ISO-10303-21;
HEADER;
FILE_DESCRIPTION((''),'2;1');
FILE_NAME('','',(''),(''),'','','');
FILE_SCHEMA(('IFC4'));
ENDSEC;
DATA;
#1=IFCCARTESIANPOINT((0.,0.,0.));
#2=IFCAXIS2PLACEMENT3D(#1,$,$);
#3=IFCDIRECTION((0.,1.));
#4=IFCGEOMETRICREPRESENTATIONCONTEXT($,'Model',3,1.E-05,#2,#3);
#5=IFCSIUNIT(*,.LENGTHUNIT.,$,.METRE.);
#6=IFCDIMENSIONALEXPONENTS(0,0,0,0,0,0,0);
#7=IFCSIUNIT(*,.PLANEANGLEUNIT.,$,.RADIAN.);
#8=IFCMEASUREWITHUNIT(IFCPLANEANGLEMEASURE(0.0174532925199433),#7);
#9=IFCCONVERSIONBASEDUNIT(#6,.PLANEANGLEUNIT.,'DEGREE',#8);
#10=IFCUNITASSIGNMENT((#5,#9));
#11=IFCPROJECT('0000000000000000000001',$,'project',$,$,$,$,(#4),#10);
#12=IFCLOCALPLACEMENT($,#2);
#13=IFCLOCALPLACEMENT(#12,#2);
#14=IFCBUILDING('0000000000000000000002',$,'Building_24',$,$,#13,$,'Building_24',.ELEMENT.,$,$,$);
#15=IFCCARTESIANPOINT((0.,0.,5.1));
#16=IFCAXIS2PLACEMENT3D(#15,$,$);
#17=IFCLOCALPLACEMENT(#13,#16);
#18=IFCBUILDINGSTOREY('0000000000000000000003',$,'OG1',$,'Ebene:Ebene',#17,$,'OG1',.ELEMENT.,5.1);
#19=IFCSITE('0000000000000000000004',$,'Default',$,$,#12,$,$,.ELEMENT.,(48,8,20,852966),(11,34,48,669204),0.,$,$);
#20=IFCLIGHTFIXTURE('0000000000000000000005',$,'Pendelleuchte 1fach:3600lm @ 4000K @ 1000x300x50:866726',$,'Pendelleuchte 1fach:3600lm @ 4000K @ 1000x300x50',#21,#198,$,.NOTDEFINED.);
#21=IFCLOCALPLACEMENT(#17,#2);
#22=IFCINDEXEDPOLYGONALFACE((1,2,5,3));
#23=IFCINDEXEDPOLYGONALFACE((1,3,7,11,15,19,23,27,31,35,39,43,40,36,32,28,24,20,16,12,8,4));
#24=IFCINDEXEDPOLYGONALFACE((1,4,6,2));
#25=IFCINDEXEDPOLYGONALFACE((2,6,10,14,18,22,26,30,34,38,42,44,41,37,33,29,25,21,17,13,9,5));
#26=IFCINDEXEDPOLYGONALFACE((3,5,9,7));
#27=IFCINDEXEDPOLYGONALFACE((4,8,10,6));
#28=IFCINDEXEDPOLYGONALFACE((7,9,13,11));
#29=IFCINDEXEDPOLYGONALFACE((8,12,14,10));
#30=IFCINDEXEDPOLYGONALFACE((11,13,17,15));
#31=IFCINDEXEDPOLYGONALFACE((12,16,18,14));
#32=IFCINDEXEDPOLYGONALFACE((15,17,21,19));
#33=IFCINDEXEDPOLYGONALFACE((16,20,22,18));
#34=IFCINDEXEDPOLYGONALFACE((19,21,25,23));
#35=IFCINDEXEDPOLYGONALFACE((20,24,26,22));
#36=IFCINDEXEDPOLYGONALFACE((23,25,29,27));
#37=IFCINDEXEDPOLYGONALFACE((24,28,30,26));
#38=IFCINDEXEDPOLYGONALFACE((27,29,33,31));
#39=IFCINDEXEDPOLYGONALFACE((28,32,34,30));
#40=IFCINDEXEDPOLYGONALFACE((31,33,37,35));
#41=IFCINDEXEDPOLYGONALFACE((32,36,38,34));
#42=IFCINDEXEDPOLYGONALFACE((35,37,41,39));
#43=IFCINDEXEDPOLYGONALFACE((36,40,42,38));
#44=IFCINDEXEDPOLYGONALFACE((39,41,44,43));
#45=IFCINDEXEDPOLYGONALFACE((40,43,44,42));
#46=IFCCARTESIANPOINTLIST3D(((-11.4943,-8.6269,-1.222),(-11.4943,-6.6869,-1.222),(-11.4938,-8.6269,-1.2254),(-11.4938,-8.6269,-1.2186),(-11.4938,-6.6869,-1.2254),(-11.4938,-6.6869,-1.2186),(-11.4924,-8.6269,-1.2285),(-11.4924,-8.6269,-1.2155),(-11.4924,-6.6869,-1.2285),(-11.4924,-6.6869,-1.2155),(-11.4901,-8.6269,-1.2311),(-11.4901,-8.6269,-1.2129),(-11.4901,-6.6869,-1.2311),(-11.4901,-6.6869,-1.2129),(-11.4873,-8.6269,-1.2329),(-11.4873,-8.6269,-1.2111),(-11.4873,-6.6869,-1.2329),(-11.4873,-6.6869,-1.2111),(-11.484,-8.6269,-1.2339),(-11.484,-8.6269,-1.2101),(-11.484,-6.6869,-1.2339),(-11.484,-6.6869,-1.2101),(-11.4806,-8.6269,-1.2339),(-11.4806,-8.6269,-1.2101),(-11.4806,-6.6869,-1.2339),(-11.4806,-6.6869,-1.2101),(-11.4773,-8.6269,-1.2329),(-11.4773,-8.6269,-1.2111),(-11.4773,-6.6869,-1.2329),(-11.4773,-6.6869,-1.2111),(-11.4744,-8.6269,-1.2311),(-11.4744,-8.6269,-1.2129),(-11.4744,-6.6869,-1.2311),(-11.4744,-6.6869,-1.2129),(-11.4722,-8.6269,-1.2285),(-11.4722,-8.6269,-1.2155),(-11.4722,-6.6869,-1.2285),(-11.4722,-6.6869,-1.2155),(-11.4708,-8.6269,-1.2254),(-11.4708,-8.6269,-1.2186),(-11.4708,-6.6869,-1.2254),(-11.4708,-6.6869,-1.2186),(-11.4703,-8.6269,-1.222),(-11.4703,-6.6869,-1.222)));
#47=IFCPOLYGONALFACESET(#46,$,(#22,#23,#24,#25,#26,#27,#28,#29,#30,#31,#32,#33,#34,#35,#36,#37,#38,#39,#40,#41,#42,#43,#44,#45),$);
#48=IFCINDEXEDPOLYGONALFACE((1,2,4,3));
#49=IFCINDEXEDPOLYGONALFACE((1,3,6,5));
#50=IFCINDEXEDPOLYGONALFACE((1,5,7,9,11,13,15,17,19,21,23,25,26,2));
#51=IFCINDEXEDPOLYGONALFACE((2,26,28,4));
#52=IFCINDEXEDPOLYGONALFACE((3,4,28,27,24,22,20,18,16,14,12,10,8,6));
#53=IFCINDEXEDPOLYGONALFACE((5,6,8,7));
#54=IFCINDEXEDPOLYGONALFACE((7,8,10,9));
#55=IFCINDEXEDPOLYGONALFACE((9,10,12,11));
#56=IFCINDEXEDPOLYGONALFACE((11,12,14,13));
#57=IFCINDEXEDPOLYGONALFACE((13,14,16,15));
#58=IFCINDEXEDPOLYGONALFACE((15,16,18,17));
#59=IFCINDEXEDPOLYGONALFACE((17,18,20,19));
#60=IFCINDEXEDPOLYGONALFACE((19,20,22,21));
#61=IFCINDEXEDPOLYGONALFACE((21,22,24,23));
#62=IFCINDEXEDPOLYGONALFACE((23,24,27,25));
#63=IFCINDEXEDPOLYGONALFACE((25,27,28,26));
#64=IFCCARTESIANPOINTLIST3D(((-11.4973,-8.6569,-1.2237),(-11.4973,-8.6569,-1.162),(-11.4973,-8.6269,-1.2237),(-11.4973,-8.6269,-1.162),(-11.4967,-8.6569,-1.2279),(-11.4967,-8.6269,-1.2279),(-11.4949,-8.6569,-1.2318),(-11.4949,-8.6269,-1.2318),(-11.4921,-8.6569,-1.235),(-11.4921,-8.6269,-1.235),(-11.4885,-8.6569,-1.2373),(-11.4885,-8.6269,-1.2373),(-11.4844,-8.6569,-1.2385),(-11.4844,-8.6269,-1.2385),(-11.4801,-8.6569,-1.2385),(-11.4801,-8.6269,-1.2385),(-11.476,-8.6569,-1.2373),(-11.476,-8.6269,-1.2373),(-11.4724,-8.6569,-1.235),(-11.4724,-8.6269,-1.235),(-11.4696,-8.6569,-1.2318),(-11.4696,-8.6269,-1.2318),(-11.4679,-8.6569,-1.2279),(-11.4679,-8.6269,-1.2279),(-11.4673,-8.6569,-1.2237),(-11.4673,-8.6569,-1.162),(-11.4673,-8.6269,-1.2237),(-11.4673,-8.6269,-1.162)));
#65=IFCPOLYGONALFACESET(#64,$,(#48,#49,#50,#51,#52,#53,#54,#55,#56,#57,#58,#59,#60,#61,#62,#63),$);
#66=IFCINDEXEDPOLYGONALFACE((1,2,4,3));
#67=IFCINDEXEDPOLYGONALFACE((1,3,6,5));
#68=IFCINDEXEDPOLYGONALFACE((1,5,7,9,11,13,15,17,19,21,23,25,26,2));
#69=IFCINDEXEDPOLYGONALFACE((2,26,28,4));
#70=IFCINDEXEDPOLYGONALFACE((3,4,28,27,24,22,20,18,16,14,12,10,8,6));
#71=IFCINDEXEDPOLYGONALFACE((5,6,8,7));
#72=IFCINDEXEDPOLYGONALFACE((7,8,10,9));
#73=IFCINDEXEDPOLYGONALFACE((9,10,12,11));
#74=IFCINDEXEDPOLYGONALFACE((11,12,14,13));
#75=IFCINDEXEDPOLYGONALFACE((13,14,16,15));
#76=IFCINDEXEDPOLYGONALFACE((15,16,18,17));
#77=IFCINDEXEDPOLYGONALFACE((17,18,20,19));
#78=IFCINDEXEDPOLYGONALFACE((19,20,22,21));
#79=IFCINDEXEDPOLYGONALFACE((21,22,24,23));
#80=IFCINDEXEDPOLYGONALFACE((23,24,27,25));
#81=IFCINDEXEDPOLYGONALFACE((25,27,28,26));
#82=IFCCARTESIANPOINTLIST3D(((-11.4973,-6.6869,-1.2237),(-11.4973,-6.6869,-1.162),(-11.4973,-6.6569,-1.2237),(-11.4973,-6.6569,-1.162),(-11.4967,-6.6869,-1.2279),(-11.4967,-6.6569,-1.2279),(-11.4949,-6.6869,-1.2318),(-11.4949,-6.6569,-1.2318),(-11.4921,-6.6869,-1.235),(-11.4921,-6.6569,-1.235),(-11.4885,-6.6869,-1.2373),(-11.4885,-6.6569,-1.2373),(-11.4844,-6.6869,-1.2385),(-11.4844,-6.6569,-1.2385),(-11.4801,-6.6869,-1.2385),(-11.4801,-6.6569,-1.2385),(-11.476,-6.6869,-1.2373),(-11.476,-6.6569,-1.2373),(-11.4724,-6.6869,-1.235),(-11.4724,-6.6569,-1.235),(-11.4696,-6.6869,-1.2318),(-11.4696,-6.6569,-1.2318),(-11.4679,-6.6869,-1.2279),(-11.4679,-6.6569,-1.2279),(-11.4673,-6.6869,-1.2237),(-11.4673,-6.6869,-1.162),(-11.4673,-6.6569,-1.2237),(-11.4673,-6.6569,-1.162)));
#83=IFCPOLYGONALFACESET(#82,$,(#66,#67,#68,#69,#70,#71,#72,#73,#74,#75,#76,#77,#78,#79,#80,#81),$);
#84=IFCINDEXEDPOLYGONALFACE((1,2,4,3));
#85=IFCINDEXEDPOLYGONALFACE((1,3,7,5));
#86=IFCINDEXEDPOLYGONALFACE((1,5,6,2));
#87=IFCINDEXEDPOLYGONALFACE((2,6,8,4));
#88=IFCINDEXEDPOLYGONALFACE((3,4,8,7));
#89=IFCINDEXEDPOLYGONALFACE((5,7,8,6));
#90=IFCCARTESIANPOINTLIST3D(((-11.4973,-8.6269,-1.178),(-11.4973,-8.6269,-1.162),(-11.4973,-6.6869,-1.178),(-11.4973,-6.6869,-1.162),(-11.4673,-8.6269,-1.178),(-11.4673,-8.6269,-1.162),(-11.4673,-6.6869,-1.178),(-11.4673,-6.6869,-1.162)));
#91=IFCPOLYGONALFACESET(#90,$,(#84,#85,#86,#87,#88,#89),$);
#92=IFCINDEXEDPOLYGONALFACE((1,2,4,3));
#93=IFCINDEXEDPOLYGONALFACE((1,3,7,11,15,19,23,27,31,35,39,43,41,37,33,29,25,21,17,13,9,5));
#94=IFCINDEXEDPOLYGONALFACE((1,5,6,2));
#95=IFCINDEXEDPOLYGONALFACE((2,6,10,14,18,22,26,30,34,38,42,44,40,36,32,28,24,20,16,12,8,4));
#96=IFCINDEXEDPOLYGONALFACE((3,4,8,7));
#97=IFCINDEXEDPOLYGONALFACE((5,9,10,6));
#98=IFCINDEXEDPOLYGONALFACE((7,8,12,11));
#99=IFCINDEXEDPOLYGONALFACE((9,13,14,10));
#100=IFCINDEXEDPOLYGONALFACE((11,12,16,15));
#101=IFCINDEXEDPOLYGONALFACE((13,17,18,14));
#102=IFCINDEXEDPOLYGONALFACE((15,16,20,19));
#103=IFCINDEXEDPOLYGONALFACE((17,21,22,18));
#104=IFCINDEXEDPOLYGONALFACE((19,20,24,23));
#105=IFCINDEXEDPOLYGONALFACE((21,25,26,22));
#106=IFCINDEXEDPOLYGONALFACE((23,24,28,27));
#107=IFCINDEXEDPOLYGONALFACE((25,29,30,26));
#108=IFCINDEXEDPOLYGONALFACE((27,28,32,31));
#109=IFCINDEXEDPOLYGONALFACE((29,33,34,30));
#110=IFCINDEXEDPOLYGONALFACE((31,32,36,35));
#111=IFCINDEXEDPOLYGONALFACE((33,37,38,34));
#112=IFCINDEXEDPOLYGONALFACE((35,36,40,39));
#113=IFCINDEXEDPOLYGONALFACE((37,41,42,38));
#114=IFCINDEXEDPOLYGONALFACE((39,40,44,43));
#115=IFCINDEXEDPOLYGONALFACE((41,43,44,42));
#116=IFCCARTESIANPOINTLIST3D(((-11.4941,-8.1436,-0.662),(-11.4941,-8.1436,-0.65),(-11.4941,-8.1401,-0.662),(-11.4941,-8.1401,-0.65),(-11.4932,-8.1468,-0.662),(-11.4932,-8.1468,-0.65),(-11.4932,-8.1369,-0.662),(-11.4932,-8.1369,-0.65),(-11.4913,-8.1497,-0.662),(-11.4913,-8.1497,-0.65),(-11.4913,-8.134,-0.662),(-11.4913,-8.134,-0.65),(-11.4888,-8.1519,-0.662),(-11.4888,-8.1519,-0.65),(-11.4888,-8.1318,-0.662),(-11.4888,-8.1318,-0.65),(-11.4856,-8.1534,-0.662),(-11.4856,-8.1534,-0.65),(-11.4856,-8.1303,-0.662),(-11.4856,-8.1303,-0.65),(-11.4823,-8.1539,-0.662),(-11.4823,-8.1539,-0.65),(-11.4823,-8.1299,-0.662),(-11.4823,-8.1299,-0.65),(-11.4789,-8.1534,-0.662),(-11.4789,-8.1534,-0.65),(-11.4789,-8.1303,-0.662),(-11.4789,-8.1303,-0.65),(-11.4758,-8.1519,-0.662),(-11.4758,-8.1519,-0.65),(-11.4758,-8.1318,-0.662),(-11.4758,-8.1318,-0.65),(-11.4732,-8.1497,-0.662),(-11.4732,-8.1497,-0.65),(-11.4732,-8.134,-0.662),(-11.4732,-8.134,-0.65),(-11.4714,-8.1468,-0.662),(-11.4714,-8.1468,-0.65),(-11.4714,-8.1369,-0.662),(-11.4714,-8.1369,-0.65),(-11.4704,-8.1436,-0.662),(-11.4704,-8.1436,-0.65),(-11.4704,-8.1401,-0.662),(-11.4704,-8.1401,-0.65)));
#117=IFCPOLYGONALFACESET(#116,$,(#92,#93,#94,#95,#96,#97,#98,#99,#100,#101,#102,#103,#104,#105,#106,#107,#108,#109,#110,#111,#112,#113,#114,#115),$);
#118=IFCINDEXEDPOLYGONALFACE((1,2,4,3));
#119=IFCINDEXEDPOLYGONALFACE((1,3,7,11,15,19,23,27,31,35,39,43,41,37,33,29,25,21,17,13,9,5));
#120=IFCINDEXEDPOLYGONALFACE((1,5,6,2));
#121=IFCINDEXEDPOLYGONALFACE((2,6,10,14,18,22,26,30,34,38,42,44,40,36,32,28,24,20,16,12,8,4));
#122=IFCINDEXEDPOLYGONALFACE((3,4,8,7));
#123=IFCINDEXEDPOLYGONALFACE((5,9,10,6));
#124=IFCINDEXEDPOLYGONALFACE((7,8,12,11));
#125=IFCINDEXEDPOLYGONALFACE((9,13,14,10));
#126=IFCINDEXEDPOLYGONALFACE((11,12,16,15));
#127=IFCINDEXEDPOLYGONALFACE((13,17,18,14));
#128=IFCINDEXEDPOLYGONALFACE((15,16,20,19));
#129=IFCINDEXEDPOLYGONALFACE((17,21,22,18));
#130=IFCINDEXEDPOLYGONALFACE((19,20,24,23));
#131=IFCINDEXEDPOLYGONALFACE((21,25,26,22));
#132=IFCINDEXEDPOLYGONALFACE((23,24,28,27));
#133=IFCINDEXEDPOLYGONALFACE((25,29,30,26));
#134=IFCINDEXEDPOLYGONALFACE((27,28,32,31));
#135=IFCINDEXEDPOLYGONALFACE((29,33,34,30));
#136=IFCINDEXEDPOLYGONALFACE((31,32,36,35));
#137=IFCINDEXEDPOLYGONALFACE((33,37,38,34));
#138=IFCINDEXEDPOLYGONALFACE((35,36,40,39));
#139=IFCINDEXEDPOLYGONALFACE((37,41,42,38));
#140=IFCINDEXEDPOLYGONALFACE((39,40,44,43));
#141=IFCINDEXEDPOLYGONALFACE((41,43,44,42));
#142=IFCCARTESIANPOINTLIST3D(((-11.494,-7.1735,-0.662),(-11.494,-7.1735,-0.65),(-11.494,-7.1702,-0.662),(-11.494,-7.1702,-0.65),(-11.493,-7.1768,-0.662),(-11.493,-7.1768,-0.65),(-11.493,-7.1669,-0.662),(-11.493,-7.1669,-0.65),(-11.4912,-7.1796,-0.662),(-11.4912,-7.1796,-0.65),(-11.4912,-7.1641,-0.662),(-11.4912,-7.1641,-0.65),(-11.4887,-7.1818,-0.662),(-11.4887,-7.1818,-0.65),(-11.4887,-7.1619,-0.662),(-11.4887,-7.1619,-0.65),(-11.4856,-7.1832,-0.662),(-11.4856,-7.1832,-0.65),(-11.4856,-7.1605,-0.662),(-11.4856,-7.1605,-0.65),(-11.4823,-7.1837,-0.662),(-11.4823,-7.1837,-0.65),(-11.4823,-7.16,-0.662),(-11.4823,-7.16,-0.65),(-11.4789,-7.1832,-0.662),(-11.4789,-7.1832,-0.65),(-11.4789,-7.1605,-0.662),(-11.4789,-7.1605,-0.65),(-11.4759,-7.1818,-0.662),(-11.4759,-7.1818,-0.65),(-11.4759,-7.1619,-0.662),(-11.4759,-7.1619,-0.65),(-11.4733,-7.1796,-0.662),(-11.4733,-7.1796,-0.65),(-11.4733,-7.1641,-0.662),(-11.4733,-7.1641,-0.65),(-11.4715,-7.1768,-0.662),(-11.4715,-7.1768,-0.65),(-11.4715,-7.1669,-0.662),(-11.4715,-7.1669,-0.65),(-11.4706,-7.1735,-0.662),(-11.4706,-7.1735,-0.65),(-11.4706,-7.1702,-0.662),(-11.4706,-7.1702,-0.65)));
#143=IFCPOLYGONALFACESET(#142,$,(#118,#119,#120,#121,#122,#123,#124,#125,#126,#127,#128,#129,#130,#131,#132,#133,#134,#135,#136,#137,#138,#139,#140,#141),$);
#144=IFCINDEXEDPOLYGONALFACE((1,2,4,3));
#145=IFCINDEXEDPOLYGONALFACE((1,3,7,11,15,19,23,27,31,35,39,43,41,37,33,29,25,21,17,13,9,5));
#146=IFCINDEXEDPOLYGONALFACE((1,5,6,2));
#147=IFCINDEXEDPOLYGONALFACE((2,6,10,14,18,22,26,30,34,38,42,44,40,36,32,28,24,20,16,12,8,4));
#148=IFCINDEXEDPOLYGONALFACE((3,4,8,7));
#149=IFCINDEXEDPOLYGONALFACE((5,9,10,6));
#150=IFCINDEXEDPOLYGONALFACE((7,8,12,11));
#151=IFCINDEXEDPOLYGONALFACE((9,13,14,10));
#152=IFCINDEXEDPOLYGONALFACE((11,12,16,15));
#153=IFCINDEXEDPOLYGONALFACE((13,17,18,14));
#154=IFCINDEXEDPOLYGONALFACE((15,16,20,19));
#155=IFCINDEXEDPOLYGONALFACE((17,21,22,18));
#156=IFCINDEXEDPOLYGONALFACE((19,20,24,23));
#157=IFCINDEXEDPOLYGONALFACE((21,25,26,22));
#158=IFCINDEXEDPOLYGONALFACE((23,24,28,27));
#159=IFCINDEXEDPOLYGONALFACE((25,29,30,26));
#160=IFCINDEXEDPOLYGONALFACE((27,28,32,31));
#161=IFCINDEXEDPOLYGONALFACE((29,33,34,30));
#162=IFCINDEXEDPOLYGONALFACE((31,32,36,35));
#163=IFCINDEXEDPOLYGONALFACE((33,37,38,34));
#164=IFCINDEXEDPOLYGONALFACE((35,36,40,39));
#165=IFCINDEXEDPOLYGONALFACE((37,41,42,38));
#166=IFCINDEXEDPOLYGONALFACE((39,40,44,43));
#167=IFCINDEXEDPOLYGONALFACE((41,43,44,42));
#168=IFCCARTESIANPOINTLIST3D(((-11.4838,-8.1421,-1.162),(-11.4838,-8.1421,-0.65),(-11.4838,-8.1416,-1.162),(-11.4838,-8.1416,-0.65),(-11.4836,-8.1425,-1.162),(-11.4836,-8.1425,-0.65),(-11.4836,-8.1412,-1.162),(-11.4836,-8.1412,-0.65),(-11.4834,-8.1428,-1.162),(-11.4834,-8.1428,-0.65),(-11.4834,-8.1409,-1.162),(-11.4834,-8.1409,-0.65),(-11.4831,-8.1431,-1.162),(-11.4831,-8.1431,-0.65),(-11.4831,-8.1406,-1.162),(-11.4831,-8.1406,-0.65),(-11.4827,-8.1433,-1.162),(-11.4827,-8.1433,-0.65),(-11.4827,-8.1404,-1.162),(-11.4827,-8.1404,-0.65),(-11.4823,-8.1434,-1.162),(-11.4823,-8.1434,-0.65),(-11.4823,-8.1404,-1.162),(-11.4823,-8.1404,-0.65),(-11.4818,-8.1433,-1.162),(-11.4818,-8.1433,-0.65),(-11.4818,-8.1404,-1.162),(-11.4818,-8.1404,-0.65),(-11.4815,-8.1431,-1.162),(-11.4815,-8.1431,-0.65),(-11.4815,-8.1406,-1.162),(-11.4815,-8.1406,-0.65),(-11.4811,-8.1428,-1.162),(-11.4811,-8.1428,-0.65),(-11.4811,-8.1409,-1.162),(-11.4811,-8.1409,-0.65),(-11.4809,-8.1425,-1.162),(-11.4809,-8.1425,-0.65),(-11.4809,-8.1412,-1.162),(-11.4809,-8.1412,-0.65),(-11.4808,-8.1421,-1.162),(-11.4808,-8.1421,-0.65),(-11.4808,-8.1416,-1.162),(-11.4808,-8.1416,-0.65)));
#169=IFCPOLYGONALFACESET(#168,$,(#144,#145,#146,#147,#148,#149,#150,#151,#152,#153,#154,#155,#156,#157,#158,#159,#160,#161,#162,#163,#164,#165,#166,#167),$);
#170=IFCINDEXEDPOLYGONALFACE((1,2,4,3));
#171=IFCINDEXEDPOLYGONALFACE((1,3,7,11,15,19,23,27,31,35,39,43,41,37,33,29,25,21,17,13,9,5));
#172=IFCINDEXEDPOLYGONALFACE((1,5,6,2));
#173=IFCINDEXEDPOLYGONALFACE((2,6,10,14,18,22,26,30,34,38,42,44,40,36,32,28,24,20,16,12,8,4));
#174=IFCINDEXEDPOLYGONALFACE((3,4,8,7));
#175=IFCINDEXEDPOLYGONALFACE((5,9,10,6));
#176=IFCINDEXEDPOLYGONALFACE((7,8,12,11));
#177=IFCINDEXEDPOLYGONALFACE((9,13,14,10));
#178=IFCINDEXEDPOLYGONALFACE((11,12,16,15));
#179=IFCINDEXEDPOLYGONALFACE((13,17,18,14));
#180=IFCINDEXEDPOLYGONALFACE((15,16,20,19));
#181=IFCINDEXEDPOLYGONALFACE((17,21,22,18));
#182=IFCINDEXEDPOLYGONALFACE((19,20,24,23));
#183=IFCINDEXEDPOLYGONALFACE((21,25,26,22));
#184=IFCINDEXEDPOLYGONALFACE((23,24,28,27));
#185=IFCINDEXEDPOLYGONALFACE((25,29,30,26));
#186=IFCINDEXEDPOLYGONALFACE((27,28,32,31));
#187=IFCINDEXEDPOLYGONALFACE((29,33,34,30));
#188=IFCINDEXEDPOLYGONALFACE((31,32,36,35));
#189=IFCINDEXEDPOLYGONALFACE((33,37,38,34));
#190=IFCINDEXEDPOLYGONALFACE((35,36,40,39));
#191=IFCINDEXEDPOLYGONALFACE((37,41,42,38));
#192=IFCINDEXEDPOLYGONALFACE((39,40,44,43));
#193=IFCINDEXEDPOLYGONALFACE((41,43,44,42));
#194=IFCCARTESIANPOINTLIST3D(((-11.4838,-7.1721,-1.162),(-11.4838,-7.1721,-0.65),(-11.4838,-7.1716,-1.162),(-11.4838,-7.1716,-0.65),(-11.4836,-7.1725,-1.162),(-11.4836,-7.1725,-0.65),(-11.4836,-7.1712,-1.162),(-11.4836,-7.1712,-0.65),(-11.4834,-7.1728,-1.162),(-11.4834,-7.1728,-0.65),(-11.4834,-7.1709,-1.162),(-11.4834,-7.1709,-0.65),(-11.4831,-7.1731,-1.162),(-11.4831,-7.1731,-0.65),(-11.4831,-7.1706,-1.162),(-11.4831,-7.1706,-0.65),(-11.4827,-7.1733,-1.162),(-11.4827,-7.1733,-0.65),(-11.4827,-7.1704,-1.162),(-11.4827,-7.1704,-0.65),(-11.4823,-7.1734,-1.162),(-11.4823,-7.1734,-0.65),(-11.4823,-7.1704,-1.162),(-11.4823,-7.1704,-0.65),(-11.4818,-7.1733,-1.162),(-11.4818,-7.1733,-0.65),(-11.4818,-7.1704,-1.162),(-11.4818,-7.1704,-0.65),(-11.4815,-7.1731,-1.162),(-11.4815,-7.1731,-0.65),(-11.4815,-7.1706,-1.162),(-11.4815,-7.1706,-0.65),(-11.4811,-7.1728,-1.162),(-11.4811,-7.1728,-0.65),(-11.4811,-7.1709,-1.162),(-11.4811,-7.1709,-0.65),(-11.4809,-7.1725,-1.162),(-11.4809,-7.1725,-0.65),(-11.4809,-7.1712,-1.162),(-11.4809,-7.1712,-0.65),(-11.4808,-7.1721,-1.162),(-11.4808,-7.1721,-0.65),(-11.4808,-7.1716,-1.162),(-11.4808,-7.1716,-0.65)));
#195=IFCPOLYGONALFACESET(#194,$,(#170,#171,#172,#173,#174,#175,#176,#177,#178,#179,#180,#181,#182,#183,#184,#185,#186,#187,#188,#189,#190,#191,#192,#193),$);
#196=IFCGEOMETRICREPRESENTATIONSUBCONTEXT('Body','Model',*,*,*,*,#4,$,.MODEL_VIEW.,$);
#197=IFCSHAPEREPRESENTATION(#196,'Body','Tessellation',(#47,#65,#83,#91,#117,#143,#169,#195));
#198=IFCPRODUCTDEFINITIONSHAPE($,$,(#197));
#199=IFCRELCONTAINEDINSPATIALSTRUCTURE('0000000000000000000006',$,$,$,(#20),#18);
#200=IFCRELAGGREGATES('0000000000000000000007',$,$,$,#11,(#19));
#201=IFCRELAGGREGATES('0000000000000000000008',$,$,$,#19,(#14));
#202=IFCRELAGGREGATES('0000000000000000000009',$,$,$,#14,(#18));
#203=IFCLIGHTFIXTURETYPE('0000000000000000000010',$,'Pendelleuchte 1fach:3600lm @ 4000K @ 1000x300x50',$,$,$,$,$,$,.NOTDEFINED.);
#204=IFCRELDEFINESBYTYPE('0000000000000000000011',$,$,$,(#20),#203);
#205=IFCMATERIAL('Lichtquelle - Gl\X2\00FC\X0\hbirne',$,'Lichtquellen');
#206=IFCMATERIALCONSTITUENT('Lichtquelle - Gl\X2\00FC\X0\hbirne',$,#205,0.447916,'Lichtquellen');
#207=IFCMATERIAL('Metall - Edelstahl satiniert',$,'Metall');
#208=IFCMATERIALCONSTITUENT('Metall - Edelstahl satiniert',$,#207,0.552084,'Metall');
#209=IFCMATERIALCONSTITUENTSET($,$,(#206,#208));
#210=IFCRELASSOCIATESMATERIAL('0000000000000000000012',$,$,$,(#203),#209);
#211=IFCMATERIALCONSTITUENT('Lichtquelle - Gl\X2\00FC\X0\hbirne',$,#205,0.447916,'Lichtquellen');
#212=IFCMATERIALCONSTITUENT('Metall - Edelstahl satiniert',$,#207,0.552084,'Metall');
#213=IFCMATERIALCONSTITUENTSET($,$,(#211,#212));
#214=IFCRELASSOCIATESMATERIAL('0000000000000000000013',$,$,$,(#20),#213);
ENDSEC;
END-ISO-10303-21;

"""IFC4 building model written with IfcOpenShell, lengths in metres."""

from ifc_helpers import new_model, entity, si_unit, converted_unit, direction, frame, origin, place, context, subcontext, project, spatial, line, arc, indexed_curve, outline, extrude, source, transform, mapped, material, constituent, constituent_set, type_object, type_shapes, element, save


model = new_model("IFC4")

# Units and contexts
model_context = context("Model", 3, precision=1e-05, world=origin(), true_north=direction((0.0, 1.0)))
body_context = subcontext(model_context, "Body", "Model", "MODEL_VIEW")
ifc_project = project(units=[si_unit("LENGTHUNIT", "METRE"), converted_unit("PLANEANGLEUNIT", "DEGREE", entity("IfcPlaneAngleMeasure", 0.0174532925199433), si_unit("PLANEANGLEUNIT", "RADIAN"), dimensions=[0, 0, 0, 0, 0, 0, 0])], contexts=[model_context])

# Site, building, storey
site_placement = place(None, origin())
site = spatial("IfcSite", under=ifc_project, at=site_placement, Name="Default", CompositionType="ELEMENT", RefLatitude=(48, 8, 20, 852966), RefLongitude=(11, 34, 48, 669204), RefElevation=0.0)
building_placement = place(site_placement, origin())
building = spatial("IfcBuilding", under=site, at=building_placement, Name="Building_24", LongName="Building_24", CompositionType="ELEMENT")
storey_placement = place(building_placement, frame((0.0, 0.0, 5.1)))
storey = spatial("IfcBuildingStorey", under=building, at=storey_placement, Name="OG1", ObjectType="Ebene:Ebene", LongName="OG1", CompositionType="ELEMENT", Elevation=5.1)

# Light fixture
ifc_material_1 = material(Name="Lichtquelle - Glühbirne", Category="Lichtquellen")
ifc_material_2 = material(Name="Metall - Edelstahl satiniert", Category="Metall")
ifc_constituent_1 = constituent(ifc_material_1, Name="Lichtquelle - Glühbirne", Category="Lichtquellen", fraction=0.447916)
ifc_constituent_2 = constituent(ifc_material_2, Name="Metall - Edelstahl satiniert", Category="Metall", fraction=0.552084)
ifc_constituent_set_1 = constituent_set(constituents=[ifc_constituent_1, ifc_constituent_2])
light_fixture_type_1 = type_object("IfcLightFixtureType", Name="Pendelleuchte 1fach:3600lm @ 4000K @ 1000x300x50", PredefinedType="NOTDEFINED", material=ifc_constituent_set_1)
shared_shape_1 = source(origin(), body_context, "Body", "SweptSolid", [
    extrude(outline(indexed_curve([(-0.012, 0.0), (0.0, -0.012), (0.012, 0.0), (0.0, 0.012)], segments=[arc(1, 2, 3), arc(3, 4, 1)], self_intersect=False)), frame((-0.97, 0.0, -0.572), z_axis=(1.0, 0.0, 0.0), x_axis=(0.0, 1.0, 0.0)), (0.0, 0.0, 1.0), 1.94),
    extrude(outline(indexed_curve([(-0.0308, -0.015), (0.0308, -0.015), (0.0308, 0.015), (-0.0308, 0.015), (-0.0458, 0.0)], segments=[line(1, 2, 3, 4), arc(4, 5, 1)], self_intersect=False)), frame((0.97, 0.0, -0.5428), z_axis=(1.0, 0.0, 0.0), x_axis=(0.0, 0.0, 1.0)), (0.0, 0.0, 1.0), 0.03),
    extrude(outline(indexed_curve([(-0.0308, -0.015), (0.0308, -0.015), (0.0308, 0.015), (-0.0308, 0.015), (-0.0458, 0.0)], segments=[line(1, 2, 3, 4), arc(4, 5, 1)], self_intersect=False)), frame((-1.0, 0.0, -0.5428), z_axis=(1.0, 0.0, 0.0), x_axis=(0.0, 0.0, 1.0)), (0.0, 0.0, 1.0), 0.03),
    extrude(outline(indexed_curve([(-0.97, -0.015), (0.97, -0.015), (0.97, 0.015), (-0.97, 0.015), (-0.97, -0.015)], self_intersect=False)), frame((0.0, 0.0, -0.528), z_axis=(0.0, 0.0, 1.0), x_axis=(-1.0, 0.0, 0.0)), (0.0, 0.0, 1.0), 0.016),
    extrude(outline(indexed_curve([(-0.012, 0.0), (0.0, -0.012), (0.012, 0.0), (0.0, 0.012)], segments=[arc(1, 2, 3), arc(3, 4, 1)], self_intersect=False)), frame((0.485, 0.0, -0.012)), (0.0, 0.0, 1.0), 0.012),
    extrude(outline(indexed_curve([(-0.0118, 0.0), (0.0, -0.0118), (0.0118, 0.0), (0.0, 0.0118)], segments=[arc(1, 2, 3), arc(3, 4, 1)], self_intersect=False)), frame((-0.485, 0.0, -0.012)), (0.0, 0.0, 1.0), 0.012),
    extrude(outline(indexed_curve([(-0.0015, 0.0), (0.0, -0.0015), (0.0015, 0.0), (0.0, 0.0015)], segments=[arc(1, 2, 3), arc(3, 4, 1)], self_intersect=False)), frame((0.485, 0.0, -0.512)), (0.0, 0.0, 1.0), 0.512),
    extrude(outline(indexed_curve([(-0.0015, 0.0), (0.0, -0.0015), (0.0015, 0.0), (0.0, 0.0015)], segments=[arc(1, 2, 3), arc(3, 4, 1)], self_intersect=False)), frame((-0.485, 0.0, -0.512)), (0.0, 0.0, 1.0), 0.512),
])
type_shapes(light_fixture_type_1, [shared_shape_1])
ifc_constituent_3 = constituent(ifc_material_1, Name="Lichtquelle - Glühbirne", Category="Lichtquellen", fraction=0.447916)
ifc_constituent_4 = constituent(ifc_material_2, Name="Metall - Edelstahl satiniert", Category="Metall", fraction=0.552084)
ifc_constituent_set_2 = constituent_set(constituents=[ifc_constituent_3, ifc_constituent_4])
light_fixture_1_placement = place(storey_placement, frame((-11.4823, -7.6569, -0.65), z_axis=(0.0, 0.0, 1.0), x_axis=(0.0, -1.0, 0.0)))
element("IfcLightFixture", 1, at=light_fixture_1_placement, inside=storey, type_object=light_fixture_type_1, material=ifc_constituent_set_2, Name="Pendelleuchte 1fach:3600lm @ 4000K @ 1000x300x50:866726", ObjectType="Pendelleuchte 1fach:3600lm @ 4000K @ 1000x300x50", PredefinedType="NOTDEFINED", context=body_context, shape_type="MappedRepresentation", body=[
    mapped(shared_shape_1, transform((0.0, 0.0, 0.0), scale=1.0)),
])

save(model, "model.ifc")
